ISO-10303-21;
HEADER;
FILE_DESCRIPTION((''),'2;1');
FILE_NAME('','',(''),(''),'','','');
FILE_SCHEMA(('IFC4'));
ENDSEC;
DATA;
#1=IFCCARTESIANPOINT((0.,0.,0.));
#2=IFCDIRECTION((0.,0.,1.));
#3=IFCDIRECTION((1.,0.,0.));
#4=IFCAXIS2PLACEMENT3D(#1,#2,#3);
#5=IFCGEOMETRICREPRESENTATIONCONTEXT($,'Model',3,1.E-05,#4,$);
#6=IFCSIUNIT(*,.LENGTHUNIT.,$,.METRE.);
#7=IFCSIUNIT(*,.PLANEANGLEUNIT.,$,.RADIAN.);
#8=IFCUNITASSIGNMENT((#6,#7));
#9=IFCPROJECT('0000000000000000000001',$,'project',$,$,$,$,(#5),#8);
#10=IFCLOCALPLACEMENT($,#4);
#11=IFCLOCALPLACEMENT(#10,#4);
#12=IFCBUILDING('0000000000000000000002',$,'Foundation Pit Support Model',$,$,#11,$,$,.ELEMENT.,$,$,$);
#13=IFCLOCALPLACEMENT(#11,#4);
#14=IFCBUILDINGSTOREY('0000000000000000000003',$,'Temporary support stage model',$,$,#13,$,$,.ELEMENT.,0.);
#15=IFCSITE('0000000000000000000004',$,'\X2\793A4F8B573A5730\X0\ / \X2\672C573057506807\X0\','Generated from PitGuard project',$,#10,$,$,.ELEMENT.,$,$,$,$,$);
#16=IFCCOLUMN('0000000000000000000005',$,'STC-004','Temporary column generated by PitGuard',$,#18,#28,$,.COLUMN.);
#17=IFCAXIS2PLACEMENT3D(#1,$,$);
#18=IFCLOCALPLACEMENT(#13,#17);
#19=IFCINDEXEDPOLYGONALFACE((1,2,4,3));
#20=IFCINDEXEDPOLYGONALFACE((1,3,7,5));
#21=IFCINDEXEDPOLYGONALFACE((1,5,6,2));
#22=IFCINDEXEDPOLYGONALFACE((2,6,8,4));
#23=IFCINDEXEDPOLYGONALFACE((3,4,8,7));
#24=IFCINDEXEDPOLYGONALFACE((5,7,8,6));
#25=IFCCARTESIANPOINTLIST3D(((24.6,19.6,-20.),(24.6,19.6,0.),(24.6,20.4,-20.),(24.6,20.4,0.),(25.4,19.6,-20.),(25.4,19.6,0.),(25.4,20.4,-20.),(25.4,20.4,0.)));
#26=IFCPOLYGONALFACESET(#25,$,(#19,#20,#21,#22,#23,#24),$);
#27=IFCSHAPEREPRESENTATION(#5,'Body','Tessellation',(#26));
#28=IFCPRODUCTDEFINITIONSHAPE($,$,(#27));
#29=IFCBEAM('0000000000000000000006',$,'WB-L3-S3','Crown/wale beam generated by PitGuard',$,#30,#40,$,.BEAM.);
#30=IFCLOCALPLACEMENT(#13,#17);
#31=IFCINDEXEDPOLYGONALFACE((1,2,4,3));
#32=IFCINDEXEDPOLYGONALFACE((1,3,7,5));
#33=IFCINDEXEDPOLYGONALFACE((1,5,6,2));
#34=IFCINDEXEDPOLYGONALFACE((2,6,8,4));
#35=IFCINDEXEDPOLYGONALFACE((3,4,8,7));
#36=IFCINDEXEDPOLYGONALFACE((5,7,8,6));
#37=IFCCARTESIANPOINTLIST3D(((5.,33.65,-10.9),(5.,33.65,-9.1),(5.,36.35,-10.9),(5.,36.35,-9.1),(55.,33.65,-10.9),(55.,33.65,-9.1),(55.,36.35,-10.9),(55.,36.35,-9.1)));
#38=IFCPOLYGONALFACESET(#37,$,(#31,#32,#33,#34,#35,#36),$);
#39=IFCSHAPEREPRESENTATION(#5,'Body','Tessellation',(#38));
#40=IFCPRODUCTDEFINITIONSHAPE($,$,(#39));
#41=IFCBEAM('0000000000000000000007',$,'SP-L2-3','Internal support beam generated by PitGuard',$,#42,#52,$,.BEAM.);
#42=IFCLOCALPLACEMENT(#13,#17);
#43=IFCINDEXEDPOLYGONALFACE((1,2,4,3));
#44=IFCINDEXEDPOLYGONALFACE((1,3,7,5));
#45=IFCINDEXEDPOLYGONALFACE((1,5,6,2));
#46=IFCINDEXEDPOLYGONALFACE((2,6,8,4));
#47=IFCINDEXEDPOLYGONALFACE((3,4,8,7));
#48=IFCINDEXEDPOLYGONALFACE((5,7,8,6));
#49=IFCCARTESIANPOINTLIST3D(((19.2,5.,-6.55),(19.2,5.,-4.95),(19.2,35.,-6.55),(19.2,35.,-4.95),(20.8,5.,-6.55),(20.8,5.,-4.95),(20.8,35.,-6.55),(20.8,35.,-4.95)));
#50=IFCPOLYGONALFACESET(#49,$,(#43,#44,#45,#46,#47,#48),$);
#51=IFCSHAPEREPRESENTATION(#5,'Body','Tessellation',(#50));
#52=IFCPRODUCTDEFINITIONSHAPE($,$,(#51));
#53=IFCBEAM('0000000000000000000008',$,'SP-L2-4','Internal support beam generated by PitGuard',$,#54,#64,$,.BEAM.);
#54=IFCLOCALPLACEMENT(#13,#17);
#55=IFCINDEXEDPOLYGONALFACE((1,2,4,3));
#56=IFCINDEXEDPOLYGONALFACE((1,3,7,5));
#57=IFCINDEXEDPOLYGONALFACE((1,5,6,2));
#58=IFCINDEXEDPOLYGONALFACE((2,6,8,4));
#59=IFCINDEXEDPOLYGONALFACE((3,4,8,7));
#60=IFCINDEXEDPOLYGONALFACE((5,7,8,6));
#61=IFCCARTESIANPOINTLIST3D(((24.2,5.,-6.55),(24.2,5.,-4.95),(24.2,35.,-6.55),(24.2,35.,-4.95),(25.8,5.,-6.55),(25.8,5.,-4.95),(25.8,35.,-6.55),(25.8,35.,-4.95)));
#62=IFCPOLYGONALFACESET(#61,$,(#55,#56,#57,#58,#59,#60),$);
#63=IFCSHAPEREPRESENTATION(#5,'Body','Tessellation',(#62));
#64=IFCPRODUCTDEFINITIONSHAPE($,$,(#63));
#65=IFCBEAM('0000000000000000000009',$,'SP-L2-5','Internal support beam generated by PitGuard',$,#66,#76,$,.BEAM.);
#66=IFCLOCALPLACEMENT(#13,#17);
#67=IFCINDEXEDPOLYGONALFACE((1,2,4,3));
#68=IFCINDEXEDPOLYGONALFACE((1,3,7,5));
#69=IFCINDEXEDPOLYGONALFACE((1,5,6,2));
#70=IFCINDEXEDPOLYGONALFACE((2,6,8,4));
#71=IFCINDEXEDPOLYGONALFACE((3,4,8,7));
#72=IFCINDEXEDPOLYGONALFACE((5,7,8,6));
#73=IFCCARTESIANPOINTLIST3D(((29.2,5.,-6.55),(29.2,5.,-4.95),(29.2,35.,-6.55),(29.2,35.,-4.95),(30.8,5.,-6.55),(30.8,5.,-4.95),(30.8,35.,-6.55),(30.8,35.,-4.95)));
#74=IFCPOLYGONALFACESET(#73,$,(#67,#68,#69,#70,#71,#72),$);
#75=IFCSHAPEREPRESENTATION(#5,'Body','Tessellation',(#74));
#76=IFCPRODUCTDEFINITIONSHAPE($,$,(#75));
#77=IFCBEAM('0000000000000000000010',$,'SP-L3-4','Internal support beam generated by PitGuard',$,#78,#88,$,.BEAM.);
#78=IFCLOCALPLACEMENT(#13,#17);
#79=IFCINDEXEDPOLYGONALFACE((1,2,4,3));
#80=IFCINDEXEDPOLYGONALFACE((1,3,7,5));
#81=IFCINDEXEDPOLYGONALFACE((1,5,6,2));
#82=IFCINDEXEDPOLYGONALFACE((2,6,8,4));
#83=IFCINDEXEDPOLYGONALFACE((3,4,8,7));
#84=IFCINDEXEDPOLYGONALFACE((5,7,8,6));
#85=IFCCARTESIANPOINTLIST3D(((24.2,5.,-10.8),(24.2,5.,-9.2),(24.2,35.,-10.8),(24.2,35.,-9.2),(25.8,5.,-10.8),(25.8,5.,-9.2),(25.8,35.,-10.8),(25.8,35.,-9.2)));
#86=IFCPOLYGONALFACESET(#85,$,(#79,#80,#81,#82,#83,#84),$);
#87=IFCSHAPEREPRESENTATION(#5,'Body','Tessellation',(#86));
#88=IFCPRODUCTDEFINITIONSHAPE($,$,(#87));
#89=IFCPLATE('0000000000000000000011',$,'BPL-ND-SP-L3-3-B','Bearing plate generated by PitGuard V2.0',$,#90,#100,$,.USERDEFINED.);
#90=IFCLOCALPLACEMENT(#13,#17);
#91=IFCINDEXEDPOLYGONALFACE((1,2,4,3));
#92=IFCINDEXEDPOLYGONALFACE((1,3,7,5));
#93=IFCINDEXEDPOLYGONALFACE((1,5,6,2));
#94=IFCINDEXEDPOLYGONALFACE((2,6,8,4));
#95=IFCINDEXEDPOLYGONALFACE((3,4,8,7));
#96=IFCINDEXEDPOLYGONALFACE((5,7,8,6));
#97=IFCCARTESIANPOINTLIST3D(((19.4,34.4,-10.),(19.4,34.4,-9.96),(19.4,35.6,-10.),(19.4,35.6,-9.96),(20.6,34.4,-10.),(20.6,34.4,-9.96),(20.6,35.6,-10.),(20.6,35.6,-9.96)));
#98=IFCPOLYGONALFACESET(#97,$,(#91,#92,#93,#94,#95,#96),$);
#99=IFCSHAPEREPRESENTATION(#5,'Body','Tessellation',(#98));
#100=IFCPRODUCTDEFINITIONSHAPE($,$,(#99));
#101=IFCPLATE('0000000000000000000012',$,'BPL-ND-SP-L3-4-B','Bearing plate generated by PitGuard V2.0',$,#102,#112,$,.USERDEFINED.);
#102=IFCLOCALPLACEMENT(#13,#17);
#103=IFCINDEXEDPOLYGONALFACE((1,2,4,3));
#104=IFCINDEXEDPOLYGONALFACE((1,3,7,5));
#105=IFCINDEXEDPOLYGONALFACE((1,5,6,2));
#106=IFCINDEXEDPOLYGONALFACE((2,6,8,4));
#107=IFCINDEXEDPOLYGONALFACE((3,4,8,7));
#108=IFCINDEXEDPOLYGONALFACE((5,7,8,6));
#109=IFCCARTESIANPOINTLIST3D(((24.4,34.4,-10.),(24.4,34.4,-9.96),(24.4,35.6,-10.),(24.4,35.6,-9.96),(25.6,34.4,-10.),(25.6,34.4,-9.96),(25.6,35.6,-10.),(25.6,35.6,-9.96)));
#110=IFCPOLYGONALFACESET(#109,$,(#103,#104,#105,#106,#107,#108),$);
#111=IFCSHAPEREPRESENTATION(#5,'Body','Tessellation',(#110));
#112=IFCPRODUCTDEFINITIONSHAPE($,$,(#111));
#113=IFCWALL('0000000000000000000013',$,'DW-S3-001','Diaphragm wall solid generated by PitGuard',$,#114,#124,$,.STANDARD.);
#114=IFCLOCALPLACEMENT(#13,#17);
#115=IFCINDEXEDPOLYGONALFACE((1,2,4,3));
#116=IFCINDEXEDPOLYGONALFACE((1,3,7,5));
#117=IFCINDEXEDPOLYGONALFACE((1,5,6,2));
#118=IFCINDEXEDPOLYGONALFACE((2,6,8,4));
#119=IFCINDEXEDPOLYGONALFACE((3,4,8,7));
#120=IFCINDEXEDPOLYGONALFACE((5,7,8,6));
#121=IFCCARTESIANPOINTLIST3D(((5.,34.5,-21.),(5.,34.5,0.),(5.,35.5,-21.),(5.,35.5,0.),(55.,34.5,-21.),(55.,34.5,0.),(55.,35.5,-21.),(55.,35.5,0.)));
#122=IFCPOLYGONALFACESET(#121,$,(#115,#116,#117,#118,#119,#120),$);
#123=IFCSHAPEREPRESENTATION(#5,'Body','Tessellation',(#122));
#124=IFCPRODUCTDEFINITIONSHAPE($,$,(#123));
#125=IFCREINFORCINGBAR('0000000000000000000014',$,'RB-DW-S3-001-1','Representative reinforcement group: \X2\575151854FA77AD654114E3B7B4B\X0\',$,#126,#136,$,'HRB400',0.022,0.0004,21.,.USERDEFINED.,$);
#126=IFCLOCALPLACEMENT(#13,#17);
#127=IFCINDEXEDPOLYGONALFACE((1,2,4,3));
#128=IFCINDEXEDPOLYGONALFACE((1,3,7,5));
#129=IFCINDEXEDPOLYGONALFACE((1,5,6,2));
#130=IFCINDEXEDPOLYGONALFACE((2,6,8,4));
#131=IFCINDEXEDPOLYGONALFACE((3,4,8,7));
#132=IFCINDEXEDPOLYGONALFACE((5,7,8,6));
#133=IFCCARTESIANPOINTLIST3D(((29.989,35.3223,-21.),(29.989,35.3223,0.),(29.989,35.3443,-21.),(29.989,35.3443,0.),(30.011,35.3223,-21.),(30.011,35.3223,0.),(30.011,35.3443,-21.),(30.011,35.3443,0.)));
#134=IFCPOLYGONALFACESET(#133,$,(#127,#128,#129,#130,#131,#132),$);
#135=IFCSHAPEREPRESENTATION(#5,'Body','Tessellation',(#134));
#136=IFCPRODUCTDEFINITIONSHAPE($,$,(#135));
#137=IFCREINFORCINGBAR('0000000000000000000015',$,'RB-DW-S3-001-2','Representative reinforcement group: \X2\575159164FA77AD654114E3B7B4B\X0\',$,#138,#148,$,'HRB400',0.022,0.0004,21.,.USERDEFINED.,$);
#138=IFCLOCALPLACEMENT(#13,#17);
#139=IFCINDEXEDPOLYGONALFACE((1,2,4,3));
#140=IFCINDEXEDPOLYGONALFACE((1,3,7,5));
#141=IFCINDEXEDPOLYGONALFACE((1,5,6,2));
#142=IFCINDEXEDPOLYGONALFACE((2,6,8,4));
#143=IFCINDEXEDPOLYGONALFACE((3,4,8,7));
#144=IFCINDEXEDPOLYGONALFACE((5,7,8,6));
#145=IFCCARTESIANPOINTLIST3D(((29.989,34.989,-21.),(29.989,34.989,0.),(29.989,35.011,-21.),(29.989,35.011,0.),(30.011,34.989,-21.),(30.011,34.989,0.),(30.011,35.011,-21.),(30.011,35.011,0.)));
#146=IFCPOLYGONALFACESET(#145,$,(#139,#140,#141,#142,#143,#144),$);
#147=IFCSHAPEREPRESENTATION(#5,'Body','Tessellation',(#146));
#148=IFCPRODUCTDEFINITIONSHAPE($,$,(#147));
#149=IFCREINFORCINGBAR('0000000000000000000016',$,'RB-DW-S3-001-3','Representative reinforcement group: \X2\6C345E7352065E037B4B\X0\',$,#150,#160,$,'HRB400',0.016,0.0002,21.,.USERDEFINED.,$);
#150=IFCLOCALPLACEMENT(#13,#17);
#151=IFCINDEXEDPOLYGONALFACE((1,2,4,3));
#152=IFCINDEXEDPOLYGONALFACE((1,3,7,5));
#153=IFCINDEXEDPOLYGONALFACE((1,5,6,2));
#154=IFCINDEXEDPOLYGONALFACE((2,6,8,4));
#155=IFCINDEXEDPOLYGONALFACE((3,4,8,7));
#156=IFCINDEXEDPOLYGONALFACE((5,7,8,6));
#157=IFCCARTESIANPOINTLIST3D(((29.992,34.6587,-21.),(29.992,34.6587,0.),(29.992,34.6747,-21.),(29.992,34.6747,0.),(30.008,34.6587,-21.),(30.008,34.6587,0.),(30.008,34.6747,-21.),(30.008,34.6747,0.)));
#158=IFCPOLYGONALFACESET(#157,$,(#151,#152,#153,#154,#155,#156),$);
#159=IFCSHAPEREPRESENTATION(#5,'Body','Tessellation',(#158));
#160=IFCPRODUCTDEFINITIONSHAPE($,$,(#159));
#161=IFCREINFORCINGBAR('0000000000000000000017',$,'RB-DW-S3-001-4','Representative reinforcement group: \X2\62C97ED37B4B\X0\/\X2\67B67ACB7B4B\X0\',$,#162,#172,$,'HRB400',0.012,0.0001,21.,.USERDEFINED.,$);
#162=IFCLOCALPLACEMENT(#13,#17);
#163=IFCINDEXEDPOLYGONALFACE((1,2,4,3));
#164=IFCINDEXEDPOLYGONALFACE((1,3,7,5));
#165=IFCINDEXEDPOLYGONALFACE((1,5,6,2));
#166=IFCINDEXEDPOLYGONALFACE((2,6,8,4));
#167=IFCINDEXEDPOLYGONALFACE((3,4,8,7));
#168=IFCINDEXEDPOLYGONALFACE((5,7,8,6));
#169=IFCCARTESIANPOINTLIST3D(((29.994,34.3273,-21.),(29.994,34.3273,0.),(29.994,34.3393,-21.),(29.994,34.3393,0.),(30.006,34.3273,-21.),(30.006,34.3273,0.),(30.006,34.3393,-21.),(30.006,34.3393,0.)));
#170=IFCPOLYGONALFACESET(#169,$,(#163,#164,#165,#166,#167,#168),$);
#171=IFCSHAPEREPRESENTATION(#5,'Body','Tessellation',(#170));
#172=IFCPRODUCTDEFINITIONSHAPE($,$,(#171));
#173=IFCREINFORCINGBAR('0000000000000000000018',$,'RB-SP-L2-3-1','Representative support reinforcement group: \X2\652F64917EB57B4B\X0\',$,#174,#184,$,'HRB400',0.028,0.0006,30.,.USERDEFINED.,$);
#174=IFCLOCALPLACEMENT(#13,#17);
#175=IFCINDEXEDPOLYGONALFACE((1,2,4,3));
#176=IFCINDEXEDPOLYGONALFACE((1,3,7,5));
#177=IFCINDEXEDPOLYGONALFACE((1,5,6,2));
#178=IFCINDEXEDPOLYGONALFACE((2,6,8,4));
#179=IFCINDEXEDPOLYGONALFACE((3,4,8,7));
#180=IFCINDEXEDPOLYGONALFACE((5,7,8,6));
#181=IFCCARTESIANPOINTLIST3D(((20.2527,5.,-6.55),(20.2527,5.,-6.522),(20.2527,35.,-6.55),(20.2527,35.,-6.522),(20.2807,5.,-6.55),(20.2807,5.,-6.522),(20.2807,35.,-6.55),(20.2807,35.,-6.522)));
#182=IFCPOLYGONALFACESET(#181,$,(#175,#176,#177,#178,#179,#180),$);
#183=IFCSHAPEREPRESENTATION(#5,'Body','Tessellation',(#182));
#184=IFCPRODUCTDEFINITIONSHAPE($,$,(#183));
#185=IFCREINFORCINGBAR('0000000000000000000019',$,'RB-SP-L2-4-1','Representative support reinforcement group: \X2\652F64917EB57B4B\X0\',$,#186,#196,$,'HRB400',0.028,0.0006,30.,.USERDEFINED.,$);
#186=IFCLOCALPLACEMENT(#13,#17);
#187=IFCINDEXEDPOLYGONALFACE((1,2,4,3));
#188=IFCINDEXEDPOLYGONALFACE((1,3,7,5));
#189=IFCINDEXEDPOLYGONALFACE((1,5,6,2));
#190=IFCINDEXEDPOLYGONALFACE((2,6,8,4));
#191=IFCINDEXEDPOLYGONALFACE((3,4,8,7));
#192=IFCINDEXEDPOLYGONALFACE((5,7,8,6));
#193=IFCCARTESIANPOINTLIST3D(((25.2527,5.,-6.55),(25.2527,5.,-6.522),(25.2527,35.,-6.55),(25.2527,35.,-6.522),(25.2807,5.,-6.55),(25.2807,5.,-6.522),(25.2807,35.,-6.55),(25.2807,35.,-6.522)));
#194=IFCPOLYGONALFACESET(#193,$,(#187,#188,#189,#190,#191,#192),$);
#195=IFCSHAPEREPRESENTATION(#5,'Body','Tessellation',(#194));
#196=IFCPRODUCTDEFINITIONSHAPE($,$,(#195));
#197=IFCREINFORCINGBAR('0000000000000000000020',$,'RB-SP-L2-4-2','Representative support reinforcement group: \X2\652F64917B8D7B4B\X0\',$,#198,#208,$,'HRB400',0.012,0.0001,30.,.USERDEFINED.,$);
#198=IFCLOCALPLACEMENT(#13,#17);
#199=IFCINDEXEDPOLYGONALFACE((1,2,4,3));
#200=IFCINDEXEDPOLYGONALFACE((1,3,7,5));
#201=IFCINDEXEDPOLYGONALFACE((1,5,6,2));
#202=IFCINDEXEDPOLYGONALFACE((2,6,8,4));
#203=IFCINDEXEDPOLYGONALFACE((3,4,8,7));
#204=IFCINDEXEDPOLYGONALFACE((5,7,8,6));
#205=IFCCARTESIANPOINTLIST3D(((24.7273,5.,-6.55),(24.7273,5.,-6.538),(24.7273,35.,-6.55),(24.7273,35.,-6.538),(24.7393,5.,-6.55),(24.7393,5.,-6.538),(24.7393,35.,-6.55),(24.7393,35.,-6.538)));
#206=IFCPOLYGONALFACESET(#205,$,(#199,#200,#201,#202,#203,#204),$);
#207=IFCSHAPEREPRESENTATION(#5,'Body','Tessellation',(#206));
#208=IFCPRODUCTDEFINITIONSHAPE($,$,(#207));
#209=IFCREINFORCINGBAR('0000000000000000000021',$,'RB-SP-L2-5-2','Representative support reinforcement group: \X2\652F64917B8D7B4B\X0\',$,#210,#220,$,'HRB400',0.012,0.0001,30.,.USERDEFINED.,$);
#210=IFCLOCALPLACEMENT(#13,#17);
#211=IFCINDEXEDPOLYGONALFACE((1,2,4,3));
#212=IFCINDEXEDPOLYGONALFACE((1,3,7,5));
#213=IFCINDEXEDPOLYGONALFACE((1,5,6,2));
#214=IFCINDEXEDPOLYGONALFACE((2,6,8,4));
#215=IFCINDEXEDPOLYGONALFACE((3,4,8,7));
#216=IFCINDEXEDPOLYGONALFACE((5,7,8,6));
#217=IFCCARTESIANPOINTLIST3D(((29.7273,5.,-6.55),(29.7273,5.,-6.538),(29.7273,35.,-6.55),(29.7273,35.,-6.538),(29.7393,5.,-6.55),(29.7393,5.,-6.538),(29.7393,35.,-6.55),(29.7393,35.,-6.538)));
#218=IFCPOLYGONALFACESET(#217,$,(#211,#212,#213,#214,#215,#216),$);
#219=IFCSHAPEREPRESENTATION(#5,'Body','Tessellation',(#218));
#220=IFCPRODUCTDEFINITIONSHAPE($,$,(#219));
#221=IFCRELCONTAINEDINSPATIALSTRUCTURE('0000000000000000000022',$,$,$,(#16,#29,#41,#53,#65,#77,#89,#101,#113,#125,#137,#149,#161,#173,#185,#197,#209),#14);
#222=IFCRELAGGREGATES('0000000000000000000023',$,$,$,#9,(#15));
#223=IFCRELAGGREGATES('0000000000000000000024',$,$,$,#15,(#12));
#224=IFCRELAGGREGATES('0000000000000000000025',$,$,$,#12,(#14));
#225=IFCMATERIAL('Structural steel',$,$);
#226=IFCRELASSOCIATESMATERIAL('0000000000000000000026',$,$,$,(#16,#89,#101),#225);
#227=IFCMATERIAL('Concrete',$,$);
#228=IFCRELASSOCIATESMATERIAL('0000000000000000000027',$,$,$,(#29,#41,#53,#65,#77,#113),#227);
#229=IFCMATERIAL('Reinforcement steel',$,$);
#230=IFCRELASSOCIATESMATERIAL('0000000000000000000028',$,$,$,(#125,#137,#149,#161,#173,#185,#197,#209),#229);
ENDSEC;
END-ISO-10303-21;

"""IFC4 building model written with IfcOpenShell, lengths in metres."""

from ifc_helpers import new_model, si_unit, frame, origin_with_axes, origin_2d, place, context, project, spatial, rectangle, extrude, material, element, save


model = new_model("IFC4")

# Units and contexts
model_context = context("Model", 3, precision=1e-05, world=origin_with_axes())
ifc_project = project(units=[si_unit("LENGTHUNIT", "METRE"), si_unit("PLANEANGLEUNIT", "RADIAN")], contexts=[model_context])

# Site, building, storey
site_placement = place(None, origin_with_axes())
site = spatial("IfcSite", under=ifc_project, at=site_placement, Name="示例场地 / 本地坐标", Description="Generated from PitGuard project", CompositionType="ELEMENT")
building_placement = place(site_placement, origin_with_axes())
building = spatial("IfcBuilding", under=site, at=building_placement, Name="Foundation Pit Support Model", CompositionType="ELEMENT")
storey_placement = place(building_placement, origin_with_axes())
storey = spatial("IfcBuildingStorey", under=building, at=storey_placement, Name="Temporary support stage model", CompositionType="ELEMENT", Elevation=0.0)

# Column
ifc_material_1 = material(Name="Structural steel")
column_placement = place(storey_placement, frame((25.0, 20.0, -20.0), z_axis=(0.0, 0.0, 1.0), x_axis=(1.0, 0.0, 0.0)))
element("IfcColumn", 1, at=column_placement, inside=storey, material=ifc_material_1, Name="STC-004", Description="Temporary column generated by PitGuard", PredefinedType="COLUMN", context=model_context, shape_type="SweptSolid", body=[
    extrude(rectangle(XDim=0.8, YDim=0.8, at=origin_2d()), origin_with_axes(), (0.0, 0.0, 1.0), 20.0),
])

# Beams
ifc_material_2 = material(Name="Concrete")
beam_placement = place(storey_placement, frame((30.0, 35.0, -10.9), z_axis=(0.0, 0.0, 1.0), x_axis=(-1.0, 0.0, 0.0)))
element("IfcBeam", 2, at=beam_placement, inside=storey, material=ifc_material_2, Name="WB-L3-S3", Description="Crown/wale beam generated by PitGuard", PredefinedType="BEAM", context=model_context, shape_type="SweptSolid", body=[
    extrude(rectangle(XDim=50.0, YDim=2.7, at=origin_2d()), origin_with_axes(), (0.0, 0.0, 1.0), 1.8),
])
for number, where, z_axis, x_axis, name in (
    (3, (20.0, 20.0, -6.55), (0.0, 0.0, 1.0), (0.0, 1.0, 0.0), "SP-L2-3"),
    (4, (25.0, 20.0, -6.55), (0.0, 0.0, 1.0), (0.0, 1.0, 0.0), "SP-L2-4"),
    (5, (30.0, 20.0, -6.55), (0.0, 0.0, 1.0), (0.0, 1.0, 0.0), "SP-L2-5"),
    (6, (25.0, 20.0, -10.8), (0.0, 0.0, 1.0), (0.0, 1.0, 0.0), "SP-L3-4"),
):
    element("IfcBeam", number, at=place(storey_placement, frame(where, z_axis=z_axis, x_axis=x_axis)), inside=storey, material=ifc_material_2, Name=name, Description="Internal support beam generated by PitGuard", PredefinedType="BEAM", context=model_context, shape_type="SweptSolid", body=[
        extrude(rectangle(XDim=30.0, YDim=1.6, at=origin_2d()), origin_with_axes(), (0.0, 0.0, 1.0), 1.6),
    ])

# Plates
for number, where, z_axis, x_axis, name in (
    (7, (20.0, 35.0, -10.0), (0.0, 0.0, 1.0), (1.0, 0.0, 0.0), "BPL-ND-SP-L3-3-B"),
    (8, (25.0, 35.0, -10.0), (0.0, 0.0, 1.0), (1.0, 0.0, 0.0), "BPL-ND-SP-L3-4-B"),
):
    element("IfcPlate", number, at=place(storey_placement, frame(where, z_axis=z_axis, x_axis=x_axis)), inside=storey, material=ifc_material_1, Name=name, Description="Bearing plate generated by PitGuard V2.0", PredefinedType="USERDEFINED", context=model_context, shape_type="SweptSolid", body=[
        extrude(rectangle(XDim=1.2, YDim=1.2, at=origin_2d()), origin_with_axes(), (0.0, 0.0, 1.0), 0.04),
    ])

# Wall
wall_placement = place(storey_placement, frame((30.0, 35.0, -21.0), z_axis=(0.0, 0.0, 1.0), x_axis=(-1.0, 0.0, 0.0)))
element("IfcWall", 9, at=wall_placement, inside=storey, material=ifc_material_2, Name="DW-S3-001", Description="Diaphragm wall solid generated by PitGuard", PredefinedType="STANDARD", context=model_context, shape_type="SweptSolid", body=[
    extrude(rectangle(XDim=50.0, YDim=1.0, at=origin_2d()), origin_with_axes(), (0.0, 0.0, 1.0), 21.0),
])

# Reinforcing bars
ifc_material_3 = material(Name="Reinforcement steel")
for number, where, z_axis, x_axis, name, description in (
    (10, (30.0, 35.3333, -21.0), (0.0, 0.0, 1.0), (1.0, 0.0, 0.0), "RB-DW-S3-001-1", "Representative reinforcement group: 坑内侧竖向主筋"),
    (11, (30.0, 35.0, -21.0), (0.0, 0.0, 1.0), (1.0, 0.0, 0.0), "RB-DW-S3-001-2", "Representative reinforcement group: 坑外侧竖向主筋"),
):
    element("IfcReinforcingBar", number, at=place(storey_placement, frame(where, z_axis=z_axis, x_axis=x_axis)), inside=storey, material=ifc_material_3, Name=name, Description=description, SteelGrade="HRB400", BarLength=21.0, CrossSectionArea=0.0004, NominalDiameter=0.022, PredefinedType="USERDEFINED", context=model_context, shape_type="SweptSolid", body=[
        extrude(rectangle(XDim=0.022, YDim=0.022, at=origin_2d()), origin_with_axes(), (0.0, 0.0, 1.0), 21.0),
    ])
reinforcing_bar_1_placement = place(storey_placement, frame((30.0, 34.6667, -21.0), z_axis=(0.0, 0.0, 1.0), x_axis=(1.0, 0.0, 0.0)))
element("IfcReinforcingBar", 12, at=reinforcing_bar_1_placement, inside=storey, material=ifc_material_3, Name="RB-DW-S3-001-3", Description="Representative reinforcement group: 水平分布筋", SteelGrade="HRB400", BarLength=21.0, CrossSectionArea=0.0002, NominalDiameter=0.016, PredefinedType="USERDEFINED", context=model_context, shape_type="SweptSolid", body=[
    extrude(rectangle(XDim=0.016, YDim=0.016, at=origin_2d()), origin_with_axes(), (0.0, 0.0, 1.0), 21.0),
])
reinforcing_bar_2_placement = place(storey_placement, frame((30.0, 34.3333, -21.0), z_axis=(0.0, 0.0, 1.0), x_axis=(1.0, 0.0, 0.0)))
element("IfcReinforcingBar", 13, at=reinforcing_bar_2_placement, inside=storey, material=ifc_material_3, Name="RB-DW-S3-001-4", Description="Representative reinforcement group: 拉结筋/架立筋", SteelGrade="HRB400", BarLength=21.0, CrossSectionArea=0.0001, NominalDiameter=0.012, PredefinedType="USERDEFINED", context=model_context, shape_type="SweptSolid", body=[
    extrude(rectangle(XDim=0.012, YDim=0.012, at=origin_2d()), origin_with_axes(), (0.0, 0.0, 1.0), 21.0),
])
for number, where, z_axis, x_axis, name in (
    (14, (20.2667, 20.0, -6.55), (0.0, 0.0, 1.0), (0.0, 1.0, 0.0), "RB-SP-L2-3-1"),
    (15, (25.2667, 20.0, -6.55), (0.0, 0.0, 1.0), (0.0, 1.0, 0.0), "RB-SP-L2-4-1"),
):
    element("IfcReinforcingBar", number, at=place(storey_placement, frame(where, z_axis=z_axis, x_axis=x_axis)), inside=storey, material=ifc_material_3, Name=name, Description="Representative support reinforcement group: 支撑纵筋", SteelGrade="HRB400", BarLength=30.0, CrossSectionArea=0.0006, NominalDiameter=0.028, PredefinedType="USERDEFINED", context=model_context, shape_type="SweptSolid", body=[
        extrude(rectangle(XDim=30.0, YDim=0.028, at=origin_2d()), origin_with_axes(), (0.0, 0.0, 1.0), 0.028),
    ])
for number, where, z_axis, x_axis, name in (
    (16, (24.7333, 20.0, -6.55), (0.0, 0.0, 1.0), (0.0, 1.0, 0.0), "RB-SP-L2-4-2"),
    (17, (29.7333, 20.0, -6.55), (0.0, 0.0, 1.0), (0.0, 1.0, 0.0), "RB-SP-L2-5-2"),
):
    element("IfcReinforcingBar", number, at=place(storey_placement, frame(where, z_axis=z_axis, x_axis=x_axis)), inside=storey, material=ifc_material_3, Name=name, Description="Representative support reinforcement group: 支撑箍筋", SteelGrade="HRB400", BarLength=30.0, CrossSectionArea=0.0001, NominalDiameter=0.012, PredefinedType="USERDEFINED", context=model_context, shape_type="SweptSolid", body=[
        extrude(rectangle(XDim=30.0, YDim=0.012, at=origin_2d()), origin_with_axes(), (0.0, 0.0, 1.0), 0.012),
    ])

save(model, "model.ifc")
